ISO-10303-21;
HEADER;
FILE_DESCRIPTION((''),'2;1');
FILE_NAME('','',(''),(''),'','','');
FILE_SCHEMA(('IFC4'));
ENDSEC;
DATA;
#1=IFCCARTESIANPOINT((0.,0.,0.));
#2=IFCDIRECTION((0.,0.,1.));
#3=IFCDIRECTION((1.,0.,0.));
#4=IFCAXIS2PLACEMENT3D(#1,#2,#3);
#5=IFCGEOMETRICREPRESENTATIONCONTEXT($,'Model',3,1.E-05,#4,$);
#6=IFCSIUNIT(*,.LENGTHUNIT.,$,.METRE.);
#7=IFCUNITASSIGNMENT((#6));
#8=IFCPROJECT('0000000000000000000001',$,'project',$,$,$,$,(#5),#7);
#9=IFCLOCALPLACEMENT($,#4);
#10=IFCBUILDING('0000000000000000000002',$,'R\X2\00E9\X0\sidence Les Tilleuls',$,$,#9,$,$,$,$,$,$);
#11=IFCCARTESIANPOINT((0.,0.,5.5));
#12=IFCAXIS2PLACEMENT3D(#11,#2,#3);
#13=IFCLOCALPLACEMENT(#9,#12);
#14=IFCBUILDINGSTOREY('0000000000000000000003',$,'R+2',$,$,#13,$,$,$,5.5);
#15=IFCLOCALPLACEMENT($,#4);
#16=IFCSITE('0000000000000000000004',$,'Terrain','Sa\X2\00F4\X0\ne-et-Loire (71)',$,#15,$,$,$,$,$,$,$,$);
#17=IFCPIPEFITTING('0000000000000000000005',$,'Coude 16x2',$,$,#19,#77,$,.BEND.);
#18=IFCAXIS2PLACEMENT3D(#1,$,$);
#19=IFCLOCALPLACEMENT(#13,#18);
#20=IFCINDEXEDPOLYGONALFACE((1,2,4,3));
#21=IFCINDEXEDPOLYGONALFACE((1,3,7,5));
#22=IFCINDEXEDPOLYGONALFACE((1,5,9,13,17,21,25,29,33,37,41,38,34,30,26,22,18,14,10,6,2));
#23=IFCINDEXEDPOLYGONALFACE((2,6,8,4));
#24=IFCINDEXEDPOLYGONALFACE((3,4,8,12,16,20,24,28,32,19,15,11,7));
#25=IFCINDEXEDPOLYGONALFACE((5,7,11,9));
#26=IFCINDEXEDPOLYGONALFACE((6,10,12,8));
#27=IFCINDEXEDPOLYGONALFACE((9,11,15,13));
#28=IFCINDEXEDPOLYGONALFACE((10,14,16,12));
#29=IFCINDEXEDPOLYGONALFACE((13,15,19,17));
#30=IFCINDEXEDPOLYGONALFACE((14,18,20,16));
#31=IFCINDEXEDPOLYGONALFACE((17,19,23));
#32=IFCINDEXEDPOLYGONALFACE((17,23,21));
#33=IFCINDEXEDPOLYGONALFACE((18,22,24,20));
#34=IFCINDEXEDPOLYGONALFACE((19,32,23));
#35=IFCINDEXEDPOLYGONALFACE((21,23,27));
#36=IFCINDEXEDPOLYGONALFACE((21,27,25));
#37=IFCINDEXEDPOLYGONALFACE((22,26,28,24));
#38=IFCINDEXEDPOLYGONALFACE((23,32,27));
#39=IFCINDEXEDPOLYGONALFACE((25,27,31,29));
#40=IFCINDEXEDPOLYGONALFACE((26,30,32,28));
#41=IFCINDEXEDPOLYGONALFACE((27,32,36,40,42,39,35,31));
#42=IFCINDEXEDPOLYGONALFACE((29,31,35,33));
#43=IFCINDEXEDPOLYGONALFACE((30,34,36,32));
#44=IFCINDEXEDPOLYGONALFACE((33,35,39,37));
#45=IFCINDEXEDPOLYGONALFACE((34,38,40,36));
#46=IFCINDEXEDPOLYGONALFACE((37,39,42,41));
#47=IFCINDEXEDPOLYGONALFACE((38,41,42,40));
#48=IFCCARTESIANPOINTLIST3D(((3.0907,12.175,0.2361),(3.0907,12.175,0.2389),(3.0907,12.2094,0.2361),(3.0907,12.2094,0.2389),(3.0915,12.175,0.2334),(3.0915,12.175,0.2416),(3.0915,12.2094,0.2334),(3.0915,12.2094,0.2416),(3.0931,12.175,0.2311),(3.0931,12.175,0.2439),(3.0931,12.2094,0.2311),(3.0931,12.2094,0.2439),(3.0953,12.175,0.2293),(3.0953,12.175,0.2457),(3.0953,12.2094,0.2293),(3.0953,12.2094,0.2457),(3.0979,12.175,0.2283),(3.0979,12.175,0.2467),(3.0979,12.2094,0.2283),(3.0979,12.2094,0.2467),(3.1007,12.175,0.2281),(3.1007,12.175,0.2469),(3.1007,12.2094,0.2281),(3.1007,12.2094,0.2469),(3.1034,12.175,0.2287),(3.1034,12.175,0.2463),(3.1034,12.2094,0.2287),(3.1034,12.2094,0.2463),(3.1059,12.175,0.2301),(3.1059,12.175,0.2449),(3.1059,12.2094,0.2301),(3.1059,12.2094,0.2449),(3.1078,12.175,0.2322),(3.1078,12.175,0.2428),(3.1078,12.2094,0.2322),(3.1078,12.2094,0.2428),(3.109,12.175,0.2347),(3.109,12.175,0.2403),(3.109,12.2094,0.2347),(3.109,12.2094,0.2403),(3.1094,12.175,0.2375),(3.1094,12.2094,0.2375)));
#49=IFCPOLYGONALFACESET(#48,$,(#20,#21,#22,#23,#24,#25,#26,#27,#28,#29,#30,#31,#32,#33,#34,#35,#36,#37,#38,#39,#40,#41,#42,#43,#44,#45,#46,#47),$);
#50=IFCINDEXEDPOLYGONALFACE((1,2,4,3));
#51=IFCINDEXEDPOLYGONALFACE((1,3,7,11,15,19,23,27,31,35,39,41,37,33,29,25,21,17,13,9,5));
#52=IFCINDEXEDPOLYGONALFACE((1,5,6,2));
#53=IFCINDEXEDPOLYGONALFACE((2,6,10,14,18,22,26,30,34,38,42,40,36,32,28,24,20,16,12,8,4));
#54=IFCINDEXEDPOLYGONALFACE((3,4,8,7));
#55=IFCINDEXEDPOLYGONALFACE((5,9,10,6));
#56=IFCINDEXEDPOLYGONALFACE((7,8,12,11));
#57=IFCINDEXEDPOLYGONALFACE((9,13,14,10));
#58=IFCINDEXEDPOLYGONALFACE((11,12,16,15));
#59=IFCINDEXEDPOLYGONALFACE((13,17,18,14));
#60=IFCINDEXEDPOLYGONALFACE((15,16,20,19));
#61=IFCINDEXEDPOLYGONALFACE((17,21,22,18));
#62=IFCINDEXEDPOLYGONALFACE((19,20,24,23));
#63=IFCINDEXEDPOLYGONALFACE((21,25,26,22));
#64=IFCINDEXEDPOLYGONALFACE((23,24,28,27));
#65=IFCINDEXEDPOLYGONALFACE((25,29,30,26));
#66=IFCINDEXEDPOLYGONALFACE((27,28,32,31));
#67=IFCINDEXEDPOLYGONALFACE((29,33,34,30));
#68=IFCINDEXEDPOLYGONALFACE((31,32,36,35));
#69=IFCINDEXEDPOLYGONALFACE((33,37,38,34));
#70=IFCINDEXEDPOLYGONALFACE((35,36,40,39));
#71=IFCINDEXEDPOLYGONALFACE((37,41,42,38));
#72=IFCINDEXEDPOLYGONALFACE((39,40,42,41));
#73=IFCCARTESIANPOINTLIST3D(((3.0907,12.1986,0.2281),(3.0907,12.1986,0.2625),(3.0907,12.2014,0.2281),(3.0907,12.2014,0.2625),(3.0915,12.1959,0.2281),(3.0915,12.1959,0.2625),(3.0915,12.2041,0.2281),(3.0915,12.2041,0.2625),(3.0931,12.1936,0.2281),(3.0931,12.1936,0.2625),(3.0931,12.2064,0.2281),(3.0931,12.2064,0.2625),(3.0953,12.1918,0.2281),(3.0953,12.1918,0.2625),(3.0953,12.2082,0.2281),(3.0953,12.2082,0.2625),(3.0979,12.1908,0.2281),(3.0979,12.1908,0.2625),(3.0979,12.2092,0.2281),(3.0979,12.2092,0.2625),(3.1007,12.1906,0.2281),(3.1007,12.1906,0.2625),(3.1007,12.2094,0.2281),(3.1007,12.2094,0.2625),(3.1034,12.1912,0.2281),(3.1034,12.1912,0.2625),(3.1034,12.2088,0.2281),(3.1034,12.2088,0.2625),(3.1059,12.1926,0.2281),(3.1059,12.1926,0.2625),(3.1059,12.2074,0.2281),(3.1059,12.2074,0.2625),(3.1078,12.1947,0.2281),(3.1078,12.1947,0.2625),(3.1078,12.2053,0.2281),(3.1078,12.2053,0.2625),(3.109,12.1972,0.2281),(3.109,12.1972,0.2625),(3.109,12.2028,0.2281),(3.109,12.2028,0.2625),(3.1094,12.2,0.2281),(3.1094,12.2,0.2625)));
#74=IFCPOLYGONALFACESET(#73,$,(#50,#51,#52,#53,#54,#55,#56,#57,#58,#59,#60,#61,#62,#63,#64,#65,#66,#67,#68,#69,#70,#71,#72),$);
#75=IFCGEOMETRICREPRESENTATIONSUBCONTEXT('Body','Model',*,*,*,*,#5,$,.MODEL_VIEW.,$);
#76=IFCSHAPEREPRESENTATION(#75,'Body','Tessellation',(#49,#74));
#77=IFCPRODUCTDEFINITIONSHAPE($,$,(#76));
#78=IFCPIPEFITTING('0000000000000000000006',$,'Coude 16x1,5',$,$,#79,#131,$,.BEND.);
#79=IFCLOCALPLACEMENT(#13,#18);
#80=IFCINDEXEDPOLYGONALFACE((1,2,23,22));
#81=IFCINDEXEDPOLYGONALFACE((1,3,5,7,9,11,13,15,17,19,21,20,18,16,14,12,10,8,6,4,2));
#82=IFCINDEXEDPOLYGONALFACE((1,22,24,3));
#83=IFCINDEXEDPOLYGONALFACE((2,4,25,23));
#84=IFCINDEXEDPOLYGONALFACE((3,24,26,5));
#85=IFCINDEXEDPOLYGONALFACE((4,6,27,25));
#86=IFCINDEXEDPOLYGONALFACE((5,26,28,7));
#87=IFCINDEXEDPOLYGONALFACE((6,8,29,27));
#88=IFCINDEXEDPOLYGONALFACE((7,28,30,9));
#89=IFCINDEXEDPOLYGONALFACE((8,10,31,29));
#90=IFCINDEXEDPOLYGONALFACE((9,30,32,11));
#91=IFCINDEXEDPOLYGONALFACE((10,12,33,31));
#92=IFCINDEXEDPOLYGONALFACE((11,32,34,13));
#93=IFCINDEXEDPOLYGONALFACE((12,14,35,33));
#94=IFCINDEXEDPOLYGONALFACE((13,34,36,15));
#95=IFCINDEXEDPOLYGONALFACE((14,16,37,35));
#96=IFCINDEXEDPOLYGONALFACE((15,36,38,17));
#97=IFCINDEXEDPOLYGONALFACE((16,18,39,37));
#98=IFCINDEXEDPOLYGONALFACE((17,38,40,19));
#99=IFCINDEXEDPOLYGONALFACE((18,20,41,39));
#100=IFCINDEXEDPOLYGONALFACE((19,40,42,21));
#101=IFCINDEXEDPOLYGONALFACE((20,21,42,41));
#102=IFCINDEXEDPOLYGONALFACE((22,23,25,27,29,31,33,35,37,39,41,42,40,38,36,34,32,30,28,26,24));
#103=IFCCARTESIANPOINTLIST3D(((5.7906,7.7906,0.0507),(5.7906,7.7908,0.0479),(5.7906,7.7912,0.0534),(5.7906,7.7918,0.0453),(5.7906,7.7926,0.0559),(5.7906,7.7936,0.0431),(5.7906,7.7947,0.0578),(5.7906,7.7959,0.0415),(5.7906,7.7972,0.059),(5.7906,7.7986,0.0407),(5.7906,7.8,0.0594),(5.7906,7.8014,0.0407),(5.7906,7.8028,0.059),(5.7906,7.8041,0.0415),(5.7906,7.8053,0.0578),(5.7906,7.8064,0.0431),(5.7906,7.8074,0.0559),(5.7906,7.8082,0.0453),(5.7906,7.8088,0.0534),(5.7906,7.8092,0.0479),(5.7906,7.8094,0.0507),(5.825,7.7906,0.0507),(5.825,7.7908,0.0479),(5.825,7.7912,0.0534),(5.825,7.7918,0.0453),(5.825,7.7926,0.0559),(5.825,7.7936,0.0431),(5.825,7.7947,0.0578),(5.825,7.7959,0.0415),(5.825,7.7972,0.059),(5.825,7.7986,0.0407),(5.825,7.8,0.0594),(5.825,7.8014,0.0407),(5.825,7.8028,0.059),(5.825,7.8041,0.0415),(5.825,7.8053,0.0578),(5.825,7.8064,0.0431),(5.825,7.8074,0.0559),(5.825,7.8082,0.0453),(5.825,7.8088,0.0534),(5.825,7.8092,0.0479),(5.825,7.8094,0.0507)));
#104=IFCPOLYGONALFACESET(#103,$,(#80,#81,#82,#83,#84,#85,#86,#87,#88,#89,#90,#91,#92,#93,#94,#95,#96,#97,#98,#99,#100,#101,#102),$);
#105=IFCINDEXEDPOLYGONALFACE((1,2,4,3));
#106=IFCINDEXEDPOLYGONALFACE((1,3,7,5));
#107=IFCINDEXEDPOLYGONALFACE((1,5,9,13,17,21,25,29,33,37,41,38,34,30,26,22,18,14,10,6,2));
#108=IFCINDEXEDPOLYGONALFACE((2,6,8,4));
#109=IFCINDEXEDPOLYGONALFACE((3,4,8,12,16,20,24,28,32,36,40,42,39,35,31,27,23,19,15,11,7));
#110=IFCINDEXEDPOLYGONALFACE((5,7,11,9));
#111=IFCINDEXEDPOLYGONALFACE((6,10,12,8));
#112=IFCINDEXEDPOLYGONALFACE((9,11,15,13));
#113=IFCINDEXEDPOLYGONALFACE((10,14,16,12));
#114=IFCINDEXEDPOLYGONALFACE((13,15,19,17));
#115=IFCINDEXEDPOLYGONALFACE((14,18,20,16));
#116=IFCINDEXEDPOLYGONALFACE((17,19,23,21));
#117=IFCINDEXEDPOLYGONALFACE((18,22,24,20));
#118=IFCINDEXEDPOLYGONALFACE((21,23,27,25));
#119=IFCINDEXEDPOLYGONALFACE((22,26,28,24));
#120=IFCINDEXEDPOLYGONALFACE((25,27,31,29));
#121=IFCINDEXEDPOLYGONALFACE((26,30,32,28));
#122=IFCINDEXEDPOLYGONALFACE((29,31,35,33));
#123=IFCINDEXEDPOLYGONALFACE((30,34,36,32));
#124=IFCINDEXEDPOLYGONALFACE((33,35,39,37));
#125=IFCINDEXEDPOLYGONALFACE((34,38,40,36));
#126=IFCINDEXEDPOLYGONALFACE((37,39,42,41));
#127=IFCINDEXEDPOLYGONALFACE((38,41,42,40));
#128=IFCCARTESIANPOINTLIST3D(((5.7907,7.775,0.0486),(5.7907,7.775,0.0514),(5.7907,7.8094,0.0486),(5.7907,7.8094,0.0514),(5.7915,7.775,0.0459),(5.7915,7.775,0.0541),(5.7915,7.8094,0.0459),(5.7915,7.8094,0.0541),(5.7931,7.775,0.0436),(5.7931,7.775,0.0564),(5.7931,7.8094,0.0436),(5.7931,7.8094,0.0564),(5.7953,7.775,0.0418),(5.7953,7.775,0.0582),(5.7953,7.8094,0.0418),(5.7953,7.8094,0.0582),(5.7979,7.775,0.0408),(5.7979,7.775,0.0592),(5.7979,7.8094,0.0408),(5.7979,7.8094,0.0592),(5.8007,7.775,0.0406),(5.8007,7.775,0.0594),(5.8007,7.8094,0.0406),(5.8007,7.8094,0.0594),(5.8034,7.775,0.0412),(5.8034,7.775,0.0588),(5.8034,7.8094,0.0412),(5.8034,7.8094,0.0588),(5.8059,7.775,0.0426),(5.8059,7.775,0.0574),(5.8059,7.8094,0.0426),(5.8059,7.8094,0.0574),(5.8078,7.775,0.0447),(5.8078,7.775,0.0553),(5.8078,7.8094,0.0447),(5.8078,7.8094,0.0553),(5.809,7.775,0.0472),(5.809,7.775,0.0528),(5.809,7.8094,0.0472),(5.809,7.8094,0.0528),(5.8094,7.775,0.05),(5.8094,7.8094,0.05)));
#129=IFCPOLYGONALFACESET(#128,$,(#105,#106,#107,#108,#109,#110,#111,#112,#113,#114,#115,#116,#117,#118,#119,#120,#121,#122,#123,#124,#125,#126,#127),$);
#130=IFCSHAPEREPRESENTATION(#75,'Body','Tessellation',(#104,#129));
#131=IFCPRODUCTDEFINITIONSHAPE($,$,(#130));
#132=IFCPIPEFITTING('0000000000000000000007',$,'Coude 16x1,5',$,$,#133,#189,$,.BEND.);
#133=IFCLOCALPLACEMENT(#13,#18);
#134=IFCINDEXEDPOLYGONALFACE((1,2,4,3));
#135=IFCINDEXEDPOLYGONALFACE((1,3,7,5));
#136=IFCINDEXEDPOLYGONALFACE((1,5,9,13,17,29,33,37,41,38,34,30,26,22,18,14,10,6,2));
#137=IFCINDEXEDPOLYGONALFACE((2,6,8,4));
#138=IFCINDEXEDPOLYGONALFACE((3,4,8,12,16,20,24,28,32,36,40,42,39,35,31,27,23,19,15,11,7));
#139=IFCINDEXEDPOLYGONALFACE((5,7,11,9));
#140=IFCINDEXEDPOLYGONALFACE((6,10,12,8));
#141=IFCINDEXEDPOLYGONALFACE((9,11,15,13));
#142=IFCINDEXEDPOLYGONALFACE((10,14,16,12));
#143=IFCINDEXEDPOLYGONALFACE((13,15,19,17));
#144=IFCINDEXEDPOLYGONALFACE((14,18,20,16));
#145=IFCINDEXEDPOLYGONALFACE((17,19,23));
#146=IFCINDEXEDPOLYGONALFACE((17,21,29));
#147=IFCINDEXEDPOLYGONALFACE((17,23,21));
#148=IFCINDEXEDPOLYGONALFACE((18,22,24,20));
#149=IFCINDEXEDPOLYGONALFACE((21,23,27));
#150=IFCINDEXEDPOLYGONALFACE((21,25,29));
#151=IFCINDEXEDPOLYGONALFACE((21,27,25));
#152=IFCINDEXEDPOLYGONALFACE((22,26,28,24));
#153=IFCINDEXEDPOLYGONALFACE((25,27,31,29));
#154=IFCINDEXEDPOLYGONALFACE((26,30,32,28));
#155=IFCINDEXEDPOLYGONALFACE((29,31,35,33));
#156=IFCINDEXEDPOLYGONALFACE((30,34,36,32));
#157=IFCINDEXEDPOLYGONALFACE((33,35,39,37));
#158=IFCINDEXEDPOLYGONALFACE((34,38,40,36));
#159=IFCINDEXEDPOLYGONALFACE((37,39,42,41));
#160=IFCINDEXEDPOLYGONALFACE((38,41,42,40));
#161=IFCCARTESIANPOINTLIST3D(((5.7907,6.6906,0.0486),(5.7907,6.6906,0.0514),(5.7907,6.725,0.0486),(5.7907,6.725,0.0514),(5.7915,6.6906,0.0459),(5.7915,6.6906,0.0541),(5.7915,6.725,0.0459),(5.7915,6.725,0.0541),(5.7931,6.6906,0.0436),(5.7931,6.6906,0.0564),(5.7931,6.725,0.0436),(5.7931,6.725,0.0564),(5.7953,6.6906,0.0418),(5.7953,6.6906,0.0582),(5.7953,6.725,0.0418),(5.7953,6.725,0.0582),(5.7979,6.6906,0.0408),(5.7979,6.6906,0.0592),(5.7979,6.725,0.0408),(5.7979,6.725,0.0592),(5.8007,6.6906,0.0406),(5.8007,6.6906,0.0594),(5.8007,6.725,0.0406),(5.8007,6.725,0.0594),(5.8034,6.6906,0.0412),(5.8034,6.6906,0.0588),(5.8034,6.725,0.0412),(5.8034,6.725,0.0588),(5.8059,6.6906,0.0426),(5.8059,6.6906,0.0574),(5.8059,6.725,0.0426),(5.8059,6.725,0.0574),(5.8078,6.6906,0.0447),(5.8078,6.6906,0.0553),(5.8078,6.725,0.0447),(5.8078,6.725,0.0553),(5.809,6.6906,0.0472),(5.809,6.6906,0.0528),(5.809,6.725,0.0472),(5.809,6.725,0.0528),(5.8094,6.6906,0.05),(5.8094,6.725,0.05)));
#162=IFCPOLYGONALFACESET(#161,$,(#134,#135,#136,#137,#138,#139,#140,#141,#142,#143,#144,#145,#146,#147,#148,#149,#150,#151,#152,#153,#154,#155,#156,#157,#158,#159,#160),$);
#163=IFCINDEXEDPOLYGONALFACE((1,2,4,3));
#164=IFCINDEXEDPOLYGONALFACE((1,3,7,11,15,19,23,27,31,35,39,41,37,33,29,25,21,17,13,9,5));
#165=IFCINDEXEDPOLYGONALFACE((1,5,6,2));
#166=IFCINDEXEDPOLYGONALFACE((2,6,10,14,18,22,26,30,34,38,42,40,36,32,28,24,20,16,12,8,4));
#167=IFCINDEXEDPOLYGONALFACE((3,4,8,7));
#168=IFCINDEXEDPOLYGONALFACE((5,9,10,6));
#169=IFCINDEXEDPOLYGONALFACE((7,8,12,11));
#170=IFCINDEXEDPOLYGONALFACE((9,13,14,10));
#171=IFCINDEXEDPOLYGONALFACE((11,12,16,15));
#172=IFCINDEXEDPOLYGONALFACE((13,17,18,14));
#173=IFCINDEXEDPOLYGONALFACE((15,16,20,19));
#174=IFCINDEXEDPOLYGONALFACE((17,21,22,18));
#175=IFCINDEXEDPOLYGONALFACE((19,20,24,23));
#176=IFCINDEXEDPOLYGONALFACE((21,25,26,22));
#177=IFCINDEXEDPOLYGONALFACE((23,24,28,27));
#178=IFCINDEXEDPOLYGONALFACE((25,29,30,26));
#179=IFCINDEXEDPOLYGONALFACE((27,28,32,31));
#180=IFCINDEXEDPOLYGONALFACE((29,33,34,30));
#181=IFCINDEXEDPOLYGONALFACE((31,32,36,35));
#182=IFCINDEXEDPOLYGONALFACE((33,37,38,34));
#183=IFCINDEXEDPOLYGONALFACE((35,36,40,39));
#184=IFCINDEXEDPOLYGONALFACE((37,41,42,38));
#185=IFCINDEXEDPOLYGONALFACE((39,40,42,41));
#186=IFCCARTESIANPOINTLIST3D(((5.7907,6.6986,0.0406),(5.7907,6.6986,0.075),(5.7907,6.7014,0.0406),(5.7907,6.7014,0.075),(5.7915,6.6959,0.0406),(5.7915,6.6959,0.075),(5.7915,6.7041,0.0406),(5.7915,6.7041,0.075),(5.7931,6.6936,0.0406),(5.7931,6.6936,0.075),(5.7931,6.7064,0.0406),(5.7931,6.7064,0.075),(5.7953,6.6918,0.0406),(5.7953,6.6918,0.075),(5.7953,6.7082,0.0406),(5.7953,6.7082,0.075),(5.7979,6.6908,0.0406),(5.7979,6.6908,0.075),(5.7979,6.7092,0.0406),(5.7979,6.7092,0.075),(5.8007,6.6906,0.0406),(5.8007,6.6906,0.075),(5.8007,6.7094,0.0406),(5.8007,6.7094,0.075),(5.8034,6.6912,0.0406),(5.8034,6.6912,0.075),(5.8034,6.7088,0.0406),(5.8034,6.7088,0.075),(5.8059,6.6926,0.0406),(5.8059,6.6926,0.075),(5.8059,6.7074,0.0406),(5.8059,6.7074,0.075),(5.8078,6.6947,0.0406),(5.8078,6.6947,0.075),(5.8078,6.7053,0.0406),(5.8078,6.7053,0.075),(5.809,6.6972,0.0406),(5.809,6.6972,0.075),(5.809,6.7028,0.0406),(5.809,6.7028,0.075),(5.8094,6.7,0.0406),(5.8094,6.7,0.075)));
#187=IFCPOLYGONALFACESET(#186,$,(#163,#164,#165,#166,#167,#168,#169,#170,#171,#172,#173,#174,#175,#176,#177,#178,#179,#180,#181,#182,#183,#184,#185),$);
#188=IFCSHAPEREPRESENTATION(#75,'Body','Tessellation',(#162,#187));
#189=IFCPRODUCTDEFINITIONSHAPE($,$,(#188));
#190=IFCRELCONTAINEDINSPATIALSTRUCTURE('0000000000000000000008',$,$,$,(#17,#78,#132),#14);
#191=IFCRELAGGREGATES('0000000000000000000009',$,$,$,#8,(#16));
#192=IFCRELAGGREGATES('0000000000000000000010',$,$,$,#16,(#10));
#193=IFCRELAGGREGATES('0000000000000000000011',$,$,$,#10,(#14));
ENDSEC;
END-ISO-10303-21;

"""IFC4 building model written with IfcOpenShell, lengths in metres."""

from ifc_helpers import new_model, si_unit, frame, origin_with_axes, place, context, subcontext, project, spatial, circle, extrude, element, save


model = new_model("IFC4")

# Units and contexts
model_context = context("Model", 3, precision=1e-05, world=origin_with_axes())
body_context = subcontext(model_context, "Body", "Model", "MODEL_VIEW")
ifc_project = project(units=[si_unit("LENGTHUNIT", "METRE")], contexts=[model_context])

# Site, building, storey
site_placement = place(None, origin_with_axes())
site = spatial("IfcSite", under=ifc_project, at=site_placement, Name="Terrain", Description="Saône-et-Loire (71)")
building_placement = place(None, origin_with_axes())
building = spatial("IfcBuilding", under=site, at=building_placement, Name="Résidence Les Tilleuls")
storey_placement = place(building_placement, frame((0.0, 0.0, 5.5), z_axis=(0.0, 0.0, 1.0), x_axis=(1.0, 0.0, 0.0)))
storey = spatial("IfcBuildingStorey", under=building, at=storey_placement, Name="R+2", Elevation=5.5)

# Pipe fittings
for number, where, z_axis, x_axis, name in (
    (1, (3.1, 12.2, 0.2375), (0.0, 0.0, 1.0), (1.0, 0.0, 0.0), "Coude 16x2"),
):
    element("IfcPipeFitting", number, at=place(storey_placement, frame(where, z_axis=z_axis, x_axis=x_axis)), inside=storey, Name=name, PredefinedType="BEND", context=body_context, shape_type="SweptSolid", body=[
        extrude(circle(Radius=0.0094), frame((0.0, 0.0094, 0.0), z_axis=(0.0, -1.0, 0.0), x_axis=(1.0, 0.0, 0.0)), (0.0, 0.0, 1.0), 0.0344),
        extrude(circle(Radius=0.0094), frame((0.0, 0.0, -0.0094), z_axis=(0.0, 0.0, 1.0), x_axis=(1.0, 0.0, 0.0)), (0.0, 0.0, 1.0), 0.0344),
    ])
pipe_fitting_1_placement = place(storey_placement, frame((5.8, 7.8, 0.05), z_axis=(0.0, 0.0, 1.0), x_axis=(1.0, 0.0, 0.0)))
element("IfcPipeFitting", 2, at=pipe_fitting_1_placement, inside=storey, Name="Coude 16x1,5", PredefinedType="BEND", context=body_context, shape_type="SweptSolid", body=[
    extrude(circle(Radius=0.0094), frame((-0.0094, 0.0, 0.0), z_axis=(1.0, 0.0, 0.0), x_axis=(0.0, 0.0, 1.0)), (0.0, 0.0, 1.0), 0.0344),
    extrude(circle(Radius=0.0094), frame((0.0, 0.0094, 0.0), z_axis=(0.0, -1.0, 0.0), x_axis=(1.0, 0.0, 0.0)), (0.0, 0.0, 1.0), 0.0344),
])
pipe_fitting_2_placement = place(storey_placement, frame((5.8, 6.7, 0.05), z_axis=(0.0, 0.0, 1.0), x_axis=(1.0, 0.0, 0.0)))
element("IfcPipeFitting", 3, at=pipe_fitting_2_placement, inside=storey, Name="Coude 16x1,5", PredefinedType="BEND", context=body_context, shape_type="SweptSolid", body=[
    extrude(circle(Radius=0.0094), frame((0.0, -0.0094, 0.0), z_axis=(0.0, 1.0, 0.0), x_axis=(1.0, 0.0, 0.0)), (0.0, 0.0, 1.0), 0.0344),
    extrude(circle(Radius=0.0094), frame((0.0, 0.0, -0.0094), z_axis=(0.0, 0.0, 1.0), x_axis=(1.0, 0.0, 0.0)), (0.0, 0.0, 1.0), 0.0344),
])

save(model, "model.ifc")
